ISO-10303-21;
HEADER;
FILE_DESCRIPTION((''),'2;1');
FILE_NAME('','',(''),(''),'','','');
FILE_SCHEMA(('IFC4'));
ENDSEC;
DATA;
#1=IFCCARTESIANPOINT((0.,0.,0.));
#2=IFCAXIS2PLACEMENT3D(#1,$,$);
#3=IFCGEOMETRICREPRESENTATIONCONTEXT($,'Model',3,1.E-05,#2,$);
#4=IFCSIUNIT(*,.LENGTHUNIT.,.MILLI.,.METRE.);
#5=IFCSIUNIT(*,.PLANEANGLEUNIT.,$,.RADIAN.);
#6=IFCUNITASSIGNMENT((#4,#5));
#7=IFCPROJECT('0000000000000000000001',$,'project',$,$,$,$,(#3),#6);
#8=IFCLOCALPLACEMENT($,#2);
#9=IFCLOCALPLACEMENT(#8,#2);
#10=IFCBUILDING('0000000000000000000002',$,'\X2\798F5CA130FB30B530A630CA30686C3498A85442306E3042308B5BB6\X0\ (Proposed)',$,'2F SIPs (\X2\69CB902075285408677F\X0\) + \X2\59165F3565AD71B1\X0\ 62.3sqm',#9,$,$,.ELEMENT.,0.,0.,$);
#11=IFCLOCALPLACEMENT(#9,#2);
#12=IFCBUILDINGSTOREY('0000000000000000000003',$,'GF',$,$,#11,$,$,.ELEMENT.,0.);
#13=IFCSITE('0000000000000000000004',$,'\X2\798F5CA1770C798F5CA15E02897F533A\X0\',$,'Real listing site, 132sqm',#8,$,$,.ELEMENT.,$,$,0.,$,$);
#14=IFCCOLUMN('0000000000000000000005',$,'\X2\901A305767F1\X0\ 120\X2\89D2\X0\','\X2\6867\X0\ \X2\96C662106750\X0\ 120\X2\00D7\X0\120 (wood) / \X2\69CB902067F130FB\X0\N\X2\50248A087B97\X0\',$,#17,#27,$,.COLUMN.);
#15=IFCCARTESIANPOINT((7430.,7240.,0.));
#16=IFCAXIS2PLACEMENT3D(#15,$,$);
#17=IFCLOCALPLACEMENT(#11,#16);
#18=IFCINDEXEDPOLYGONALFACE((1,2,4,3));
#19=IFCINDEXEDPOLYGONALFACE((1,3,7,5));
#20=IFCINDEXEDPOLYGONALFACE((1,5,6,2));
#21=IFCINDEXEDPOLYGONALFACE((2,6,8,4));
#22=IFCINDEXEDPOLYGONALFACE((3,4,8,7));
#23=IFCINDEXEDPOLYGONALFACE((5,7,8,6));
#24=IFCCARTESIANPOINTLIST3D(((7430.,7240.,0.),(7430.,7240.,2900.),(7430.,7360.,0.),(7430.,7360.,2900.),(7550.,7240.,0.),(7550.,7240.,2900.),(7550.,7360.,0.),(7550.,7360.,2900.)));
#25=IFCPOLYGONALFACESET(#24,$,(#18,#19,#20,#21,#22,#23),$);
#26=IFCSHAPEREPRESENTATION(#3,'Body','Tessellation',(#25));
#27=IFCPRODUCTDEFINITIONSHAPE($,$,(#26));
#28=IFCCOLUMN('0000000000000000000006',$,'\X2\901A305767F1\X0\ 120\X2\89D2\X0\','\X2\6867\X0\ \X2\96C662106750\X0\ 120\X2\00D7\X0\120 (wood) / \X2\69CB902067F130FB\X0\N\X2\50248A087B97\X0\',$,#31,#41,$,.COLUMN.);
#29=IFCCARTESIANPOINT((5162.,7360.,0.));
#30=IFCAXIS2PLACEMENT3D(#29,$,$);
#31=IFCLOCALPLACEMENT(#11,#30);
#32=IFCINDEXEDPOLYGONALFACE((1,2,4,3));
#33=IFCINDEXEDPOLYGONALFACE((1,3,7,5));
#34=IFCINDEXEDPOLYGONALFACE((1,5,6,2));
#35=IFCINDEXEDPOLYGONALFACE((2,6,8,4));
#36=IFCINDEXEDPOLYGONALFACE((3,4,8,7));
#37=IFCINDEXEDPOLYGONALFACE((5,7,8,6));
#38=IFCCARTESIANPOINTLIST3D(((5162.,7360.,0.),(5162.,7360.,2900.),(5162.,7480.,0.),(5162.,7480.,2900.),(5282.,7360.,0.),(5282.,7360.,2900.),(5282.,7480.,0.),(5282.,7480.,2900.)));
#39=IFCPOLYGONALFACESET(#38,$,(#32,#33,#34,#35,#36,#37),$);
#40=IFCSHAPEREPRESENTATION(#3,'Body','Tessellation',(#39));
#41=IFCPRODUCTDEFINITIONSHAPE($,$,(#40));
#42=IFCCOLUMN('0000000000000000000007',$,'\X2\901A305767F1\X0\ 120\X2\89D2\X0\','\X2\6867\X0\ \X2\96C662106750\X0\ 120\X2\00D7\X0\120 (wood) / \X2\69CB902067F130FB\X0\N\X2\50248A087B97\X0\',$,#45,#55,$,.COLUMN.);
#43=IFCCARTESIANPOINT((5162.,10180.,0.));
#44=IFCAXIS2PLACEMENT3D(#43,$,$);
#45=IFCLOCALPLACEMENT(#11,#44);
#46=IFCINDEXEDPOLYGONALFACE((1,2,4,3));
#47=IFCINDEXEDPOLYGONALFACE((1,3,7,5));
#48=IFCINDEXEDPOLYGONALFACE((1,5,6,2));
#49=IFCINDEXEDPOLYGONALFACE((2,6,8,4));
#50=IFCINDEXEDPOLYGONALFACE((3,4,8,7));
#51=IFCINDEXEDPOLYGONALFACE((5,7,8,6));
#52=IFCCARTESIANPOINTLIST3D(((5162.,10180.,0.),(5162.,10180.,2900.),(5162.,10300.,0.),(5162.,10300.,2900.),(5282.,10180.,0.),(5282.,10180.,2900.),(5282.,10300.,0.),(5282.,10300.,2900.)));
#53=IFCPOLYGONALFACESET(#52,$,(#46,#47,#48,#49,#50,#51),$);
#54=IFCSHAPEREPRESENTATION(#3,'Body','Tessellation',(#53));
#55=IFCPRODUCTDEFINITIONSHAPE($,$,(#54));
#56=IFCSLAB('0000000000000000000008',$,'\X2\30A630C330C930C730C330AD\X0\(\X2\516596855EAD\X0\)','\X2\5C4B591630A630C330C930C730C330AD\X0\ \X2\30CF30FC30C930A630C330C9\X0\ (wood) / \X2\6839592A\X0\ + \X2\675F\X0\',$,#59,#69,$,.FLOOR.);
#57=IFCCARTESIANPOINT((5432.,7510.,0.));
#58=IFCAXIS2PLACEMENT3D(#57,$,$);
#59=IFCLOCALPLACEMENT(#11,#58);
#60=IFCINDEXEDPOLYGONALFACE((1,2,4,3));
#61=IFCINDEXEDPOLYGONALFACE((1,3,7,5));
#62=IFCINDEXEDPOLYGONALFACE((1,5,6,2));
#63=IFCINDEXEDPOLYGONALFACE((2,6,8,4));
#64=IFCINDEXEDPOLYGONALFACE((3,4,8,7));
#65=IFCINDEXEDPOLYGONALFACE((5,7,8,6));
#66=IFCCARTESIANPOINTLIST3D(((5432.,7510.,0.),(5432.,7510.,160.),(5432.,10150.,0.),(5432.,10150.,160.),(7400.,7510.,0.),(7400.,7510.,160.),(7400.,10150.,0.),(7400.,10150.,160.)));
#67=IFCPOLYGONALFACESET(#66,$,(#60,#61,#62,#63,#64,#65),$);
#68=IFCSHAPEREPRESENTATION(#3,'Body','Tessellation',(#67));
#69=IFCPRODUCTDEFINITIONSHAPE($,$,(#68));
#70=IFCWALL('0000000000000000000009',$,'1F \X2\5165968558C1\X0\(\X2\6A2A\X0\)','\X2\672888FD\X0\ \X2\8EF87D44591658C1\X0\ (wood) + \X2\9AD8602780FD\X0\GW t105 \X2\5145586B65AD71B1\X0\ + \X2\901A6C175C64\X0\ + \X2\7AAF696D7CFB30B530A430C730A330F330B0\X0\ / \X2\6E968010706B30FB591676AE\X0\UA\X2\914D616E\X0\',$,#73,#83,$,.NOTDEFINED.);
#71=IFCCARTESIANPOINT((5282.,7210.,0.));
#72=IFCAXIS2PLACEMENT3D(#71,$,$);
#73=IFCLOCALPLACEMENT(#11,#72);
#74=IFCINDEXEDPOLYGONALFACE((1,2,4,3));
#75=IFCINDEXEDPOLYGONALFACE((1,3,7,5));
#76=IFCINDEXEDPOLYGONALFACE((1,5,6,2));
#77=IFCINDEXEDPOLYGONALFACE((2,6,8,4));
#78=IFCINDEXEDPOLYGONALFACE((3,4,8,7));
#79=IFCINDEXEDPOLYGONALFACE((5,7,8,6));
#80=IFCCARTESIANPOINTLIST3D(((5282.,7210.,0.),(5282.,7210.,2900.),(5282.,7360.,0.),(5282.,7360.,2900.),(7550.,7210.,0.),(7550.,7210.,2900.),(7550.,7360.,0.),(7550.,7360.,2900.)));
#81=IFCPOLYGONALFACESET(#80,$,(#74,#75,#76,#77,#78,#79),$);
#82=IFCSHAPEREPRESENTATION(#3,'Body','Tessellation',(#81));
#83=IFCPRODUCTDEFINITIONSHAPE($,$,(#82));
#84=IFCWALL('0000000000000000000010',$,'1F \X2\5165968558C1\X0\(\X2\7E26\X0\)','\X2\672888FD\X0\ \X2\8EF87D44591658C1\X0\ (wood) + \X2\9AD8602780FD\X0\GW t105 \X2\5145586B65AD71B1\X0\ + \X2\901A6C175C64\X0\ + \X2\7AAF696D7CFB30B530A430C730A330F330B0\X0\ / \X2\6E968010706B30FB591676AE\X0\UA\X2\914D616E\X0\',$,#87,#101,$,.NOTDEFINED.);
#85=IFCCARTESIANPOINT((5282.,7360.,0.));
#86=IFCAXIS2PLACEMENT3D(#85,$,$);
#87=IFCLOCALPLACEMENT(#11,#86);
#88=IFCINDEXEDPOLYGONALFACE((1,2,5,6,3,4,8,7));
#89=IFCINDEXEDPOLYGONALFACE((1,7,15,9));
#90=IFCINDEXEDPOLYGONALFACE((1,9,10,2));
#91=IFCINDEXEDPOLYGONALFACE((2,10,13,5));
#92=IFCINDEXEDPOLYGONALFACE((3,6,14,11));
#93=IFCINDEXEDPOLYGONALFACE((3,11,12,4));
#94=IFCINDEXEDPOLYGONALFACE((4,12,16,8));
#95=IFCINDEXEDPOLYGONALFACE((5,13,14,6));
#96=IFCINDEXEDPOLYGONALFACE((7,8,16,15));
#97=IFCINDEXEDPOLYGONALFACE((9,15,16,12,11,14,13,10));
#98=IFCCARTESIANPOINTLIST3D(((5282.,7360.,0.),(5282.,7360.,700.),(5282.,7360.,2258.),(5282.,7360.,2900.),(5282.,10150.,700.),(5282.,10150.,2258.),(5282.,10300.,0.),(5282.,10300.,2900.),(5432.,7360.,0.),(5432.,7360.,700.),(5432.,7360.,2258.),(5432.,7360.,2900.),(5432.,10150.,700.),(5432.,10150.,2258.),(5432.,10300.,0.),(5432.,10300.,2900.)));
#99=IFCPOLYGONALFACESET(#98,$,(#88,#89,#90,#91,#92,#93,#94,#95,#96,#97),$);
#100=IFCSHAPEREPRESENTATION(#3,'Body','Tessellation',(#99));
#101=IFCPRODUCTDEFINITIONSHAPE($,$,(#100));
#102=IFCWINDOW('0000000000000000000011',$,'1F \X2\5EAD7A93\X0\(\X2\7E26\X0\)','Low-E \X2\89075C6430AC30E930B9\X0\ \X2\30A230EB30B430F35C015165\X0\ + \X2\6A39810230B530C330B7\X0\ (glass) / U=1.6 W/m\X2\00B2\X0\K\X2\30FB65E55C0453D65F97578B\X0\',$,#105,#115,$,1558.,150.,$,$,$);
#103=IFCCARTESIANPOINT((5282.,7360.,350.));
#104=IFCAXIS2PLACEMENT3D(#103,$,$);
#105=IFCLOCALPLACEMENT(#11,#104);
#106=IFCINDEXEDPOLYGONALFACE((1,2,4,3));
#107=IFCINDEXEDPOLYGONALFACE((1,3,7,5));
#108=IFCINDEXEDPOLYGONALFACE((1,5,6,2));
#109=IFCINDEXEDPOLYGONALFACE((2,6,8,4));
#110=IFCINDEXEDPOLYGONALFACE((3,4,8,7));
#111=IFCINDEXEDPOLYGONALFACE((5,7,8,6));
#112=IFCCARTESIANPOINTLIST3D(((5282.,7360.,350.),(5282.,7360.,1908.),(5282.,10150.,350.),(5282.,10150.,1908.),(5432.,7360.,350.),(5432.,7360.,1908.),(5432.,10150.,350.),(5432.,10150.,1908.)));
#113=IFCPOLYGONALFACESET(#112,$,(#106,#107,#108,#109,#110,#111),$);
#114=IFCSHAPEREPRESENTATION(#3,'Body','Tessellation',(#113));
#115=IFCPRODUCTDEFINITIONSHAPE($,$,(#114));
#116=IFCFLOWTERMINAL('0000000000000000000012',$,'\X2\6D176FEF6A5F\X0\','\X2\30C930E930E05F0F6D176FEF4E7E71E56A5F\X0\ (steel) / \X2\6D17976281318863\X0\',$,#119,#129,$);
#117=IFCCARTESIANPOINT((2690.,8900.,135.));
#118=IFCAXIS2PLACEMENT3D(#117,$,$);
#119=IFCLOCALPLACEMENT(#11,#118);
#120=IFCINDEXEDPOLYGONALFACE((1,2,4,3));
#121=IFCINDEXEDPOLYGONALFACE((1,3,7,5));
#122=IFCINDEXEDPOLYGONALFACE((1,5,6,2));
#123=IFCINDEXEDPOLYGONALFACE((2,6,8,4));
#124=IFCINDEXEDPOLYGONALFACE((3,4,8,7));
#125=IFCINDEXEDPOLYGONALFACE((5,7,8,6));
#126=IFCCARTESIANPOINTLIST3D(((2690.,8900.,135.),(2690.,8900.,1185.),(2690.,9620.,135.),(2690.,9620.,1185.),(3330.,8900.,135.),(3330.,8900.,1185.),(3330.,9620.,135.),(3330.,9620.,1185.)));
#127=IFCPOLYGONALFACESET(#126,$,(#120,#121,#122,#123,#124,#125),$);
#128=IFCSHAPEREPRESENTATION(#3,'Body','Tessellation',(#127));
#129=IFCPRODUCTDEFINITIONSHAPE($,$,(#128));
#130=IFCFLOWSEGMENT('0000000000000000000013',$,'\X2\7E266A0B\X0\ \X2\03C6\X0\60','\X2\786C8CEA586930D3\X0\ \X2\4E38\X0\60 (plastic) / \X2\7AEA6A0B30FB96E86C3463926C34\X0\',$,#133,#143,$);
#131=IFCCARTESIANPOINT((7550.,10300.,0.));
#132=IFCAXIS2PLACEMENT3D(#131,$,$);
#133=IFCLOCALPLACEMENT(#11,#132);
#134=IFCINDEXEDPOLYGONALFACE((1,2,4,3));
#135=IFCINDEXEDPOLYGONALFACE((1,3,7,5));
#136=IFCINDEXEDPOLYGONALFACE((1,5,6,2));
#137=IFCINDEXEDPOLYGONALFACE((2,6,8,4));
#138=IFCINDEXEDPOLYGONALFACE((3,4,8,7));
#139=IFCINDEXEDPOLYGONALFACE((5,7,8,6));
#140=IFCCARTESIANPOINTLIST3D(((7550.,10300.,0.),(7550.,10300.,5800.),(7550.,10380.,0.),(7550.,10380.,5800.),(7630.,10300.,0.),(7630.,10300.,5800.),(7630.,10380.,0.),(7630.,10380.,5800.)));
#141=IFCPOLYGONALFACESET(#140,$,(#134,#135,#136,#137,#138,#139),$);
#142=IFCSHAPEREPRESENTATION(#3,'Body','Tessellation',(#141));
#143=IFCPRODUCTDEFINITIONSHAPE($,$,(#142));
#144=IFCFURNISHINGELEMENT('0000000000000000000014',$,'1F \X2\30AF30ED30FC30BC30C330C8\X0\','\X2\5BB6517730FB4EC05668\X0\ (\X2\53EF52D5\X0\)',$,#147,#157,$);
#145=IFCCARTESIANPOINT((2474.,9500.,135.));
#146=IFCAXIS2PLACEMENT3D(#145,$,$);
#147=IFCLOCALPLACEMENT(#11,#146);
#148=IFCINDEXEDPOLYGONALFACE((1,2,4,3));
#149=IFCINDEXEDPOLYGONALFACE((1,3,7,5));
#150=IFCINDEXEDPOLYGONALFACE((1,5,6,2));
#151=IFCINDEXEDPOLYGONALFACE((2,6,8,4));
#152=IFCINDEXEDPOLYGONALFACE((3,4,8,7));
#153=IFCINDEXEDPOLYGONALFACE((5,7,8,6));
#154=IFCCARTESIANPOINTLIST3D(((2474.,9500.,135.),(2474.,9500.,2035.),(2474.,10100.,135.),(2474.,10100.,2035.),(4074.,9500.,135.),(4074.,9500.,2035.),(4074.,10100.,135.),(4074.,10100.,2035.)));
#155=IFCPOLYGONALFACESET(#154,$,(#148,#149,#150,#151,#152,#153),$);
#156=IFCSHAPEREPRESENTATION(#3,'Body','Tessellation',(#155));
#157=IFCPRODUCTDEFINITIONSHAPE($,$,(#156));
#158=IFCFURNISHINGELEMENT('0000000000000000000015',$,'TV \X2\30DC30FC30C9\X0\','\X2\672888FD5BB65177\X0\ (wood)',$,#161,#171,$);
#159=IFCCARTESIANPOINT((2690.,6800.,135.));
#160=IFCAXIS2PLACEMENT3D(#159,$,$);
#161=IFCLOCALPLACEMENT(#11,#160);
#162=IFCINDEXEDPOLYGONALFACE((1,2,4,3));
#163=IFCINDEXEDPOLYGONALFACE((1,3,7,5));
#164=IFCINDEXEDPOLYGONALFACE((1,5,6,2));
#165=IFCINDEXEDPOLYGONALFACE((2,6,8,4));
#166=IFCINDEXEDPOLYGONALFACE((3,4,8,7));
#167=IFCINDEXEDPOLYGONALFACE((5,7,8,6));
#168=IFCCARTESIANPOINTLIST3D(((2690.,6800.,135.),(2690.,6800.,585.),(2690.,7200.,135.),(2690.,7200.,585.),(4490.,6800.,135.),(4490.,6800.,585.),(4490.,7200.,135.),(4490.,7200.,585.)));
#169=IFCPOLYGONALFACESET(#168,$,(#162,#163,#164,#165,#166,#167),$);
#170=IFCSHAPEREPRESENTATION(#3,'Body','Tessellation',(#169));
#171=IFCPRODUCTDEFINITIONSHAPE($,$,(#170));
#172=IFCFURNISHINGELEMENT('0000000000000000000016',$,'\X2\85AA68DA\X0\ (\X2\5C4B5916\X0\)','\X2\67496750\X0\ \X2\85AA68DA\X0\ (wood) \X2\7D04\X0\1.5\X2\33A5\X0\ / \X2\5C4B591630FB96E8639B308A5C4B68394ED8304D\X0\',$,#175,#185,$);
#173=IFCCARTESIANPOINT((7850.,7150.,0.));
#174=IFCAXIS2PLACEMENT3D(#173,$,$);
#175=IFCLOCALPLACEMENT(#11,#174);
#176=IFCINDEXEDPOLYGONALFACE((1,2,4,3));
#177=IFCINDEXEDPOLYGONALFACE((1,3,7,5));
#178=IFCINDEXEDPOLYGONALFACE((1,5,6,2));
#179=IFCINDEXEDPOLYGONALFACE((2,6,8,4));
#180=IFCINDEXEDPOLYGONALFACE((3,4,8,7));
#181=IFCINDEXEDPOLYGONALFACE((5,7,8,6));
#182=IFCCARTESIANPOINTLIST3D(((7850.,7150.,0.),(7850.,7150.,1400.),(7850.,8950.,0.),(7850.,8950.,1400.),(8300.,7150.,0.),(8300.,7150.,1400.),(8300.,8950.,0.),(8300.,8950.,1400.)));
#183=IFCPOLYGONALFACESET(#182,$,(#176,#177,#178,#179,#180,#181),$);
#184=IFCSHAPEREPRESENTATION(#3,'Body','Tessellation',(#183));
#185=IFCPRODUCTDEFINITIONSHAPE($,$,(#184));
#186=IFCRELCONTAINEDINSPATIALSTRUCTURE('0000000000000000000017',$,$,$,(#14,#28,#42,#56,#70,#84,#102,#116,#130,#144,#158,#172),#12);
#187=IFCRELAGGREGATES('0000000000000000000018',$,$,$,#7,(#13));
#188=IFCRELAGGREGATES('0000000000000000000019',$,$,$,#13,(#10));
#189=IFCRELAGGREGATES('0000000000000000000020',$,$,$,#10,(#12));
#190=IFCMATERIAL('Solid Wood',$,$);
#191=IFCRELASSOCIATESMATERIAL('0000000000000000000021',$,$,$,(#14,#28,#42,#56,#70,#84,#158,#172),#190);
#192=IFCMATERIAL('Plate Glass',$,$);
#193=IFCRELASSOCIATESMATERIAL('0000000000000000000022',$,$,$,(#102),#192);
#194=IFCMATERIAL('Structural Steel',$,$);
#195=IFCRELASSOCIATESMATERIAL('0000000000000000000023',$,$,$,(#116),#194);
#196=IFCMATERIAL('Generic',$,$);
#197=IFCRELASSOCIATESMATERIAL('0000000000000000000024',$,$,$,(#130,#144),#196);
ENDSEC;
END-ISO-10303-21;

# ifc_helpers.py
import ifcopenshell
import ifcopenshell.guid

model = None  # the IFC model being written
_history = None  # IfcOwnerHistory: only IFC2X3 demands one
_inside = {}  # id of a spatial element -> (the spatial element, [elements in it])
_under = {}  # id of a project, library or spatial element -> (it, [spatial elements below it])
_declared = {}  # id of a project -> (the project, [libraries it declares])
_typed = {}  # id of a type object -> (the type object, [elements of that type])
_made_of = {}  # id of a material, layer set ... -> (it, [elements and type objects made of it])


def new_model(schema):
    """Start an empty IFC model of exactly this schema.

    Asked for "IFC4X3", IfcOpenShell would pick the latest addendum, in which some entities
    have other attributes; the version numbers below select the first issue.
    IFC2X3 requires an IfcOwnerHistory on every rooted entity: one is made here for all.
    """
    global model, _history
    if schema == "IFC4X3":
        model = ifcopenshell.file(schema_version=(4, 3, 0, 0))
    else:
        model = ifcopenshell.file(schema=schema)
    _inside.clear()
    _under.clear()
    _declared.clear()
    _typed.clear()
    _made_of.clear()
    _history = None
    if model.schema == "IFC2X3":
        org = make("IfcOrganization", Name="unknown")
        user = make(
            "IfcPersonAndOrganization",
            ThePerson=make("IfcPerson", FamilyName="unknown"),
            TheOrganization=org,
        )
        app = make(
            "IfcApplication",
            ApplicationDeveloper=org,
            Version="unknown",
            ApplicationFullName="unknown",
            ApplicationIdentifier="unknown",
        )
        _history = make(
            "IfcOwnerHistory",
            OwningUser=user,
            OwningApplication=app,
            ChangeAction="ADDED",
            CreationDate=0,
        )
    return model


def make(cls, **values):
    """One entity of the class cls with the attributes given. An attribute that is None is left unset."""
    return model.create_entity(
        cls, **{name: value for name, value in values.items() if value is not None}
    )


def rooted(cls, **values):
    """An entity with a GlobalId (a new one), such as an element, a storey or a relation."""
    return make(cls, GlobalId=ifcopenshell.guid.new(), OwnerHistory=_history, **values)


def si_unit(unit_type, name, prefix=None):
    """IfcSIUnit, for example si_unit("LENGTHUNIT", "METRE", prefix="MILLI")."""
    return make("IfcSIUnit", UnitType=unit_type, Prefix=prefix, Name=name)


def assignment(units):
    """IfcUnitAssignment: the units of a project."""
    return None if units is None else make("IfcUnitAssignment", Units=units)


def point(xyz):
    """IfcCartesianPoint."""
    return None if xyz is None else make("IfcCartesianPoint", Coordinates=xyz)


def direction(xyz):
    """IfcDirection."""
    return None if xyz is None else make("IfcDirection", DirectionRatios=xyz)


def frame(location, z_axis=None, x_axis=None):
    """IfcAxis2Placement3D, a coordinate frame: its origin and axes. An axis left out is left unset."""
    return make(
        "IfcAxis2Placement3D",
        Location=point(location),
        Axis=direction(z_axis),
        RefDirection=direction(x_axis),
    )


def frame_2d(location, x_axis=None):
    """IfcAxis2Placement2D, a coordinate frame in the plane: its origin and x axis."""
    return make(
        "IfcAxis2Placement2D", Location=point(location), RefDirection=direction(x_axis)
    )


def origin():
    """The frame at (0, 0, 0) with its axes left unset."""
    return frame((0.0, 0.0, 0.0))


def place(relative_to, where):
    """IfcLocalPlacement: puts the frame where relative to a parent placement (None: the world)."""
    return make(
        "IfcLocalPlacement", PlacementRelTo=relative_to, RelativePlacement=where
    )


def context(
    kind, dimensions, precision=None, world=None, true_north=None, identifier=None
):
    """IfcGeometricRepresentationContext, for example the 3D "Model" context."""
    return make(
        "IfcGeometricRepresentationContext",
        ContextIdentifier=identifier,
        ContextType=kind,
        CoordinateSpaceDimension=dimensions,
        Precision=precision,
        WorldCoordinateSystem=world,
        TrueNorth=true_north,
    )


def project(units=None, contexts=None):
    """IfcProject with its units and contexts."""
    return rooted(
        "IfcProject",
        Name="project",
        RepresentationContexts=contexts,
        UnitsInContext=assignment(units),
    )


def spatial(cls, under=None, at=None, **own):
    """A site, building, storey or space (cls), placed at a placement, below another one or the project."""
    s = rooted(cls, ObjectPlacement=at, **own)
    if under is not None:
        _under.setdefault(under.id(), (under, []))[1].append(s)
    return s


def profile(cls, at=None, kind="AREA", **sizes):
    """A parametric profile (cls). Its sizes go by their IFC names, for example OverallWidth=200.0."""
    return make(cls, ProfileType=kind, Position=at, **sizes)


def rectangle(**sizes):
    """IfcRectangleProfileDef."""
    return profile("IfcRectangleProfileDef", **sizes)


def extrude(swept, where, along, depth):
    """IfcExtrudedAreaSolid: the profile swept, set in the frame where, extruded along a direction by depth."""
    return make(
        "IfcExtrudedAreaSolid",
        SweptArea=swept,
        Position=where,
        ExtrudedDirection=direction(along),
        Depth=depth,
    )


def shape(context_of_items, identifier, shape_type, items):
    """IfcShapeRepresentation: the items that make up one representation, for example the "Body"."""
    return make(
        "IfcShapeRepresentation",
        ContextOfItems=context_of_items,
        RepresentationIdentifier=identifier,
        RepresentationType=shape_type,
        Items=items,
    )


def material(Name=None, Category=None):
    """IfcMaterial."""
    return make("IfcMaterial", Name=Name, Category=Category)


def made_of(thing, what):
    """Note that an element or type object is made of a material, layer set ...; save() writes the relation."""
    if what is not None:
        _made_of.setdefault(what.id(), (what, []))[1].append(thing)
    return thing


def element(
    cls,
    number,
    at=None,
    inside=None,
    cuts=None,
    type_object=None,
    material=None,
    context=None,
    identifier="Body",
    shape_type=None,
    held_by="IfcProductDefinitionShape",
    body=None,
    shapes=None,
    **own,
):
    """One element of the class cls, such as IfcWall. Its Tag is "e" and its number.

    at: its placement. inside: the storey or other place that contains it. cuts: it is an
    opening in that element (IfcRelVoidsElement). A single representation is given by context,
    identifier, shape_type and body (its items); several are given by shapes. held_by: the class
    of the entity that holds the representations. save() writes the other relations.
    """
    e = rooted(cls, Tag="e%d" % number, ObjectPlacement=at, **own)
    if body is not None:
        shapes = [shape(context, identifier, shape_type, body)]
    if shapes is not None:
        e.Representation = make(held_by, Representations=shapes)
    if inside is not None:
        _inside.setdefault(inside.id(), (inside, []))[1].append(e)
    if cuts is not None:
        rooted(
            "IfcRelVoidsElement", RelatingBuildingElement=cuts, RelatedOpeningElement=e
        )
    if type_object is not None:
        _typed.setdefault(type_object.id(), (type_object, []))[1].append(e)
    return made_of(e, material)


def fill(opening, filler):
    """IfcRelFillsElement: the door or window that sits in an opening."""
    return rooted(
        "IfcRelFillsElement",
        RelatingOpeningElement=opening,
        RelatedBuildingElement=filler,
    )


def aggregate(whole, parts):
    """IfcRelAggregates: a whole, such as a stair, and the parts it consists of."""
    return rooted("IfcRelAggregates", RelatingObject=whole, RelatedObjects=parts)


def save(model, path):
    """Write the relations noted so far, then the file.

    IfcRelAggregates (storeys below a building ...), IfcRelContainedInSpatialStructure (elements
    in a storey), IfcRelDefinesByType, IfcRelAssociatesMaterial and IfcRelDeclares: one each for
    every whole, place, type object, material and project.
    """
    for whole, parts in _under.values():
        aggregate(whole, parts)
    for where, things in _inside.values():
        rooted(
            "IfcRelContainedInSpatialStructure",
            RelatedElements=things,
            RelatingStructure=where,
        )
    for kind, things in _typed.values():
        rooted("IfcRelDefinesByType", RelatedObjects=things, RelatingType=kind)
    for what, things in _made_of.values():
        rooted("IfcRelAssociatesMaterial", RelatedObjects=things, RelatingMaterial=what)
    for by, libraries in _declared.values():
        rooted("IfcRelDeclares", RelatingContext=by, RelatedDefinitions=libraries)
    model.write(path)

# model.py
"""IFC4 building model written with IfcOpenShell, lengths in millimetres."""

from ifc_helpers import new_model, si_unit, frame, frame_2d, origin, place, context, project, spatial, rectangle, extrude, material, element, fill, save


model = new_model("IFC4")

# Units and contexts
model_context = context("Model", 3, precision=1e-05, world=origin())
ifc_project = project(units=[si_unit("LENGTHUNIT", "METRE", prefix="MILLI"), si_unit("PLANEANGLEUNIT", "RADIAN")], contexts=[model_context])

# Site, building, storey
site_placement = place(None, origin())
site = spatial("IfcSite", under=ifc_project, at=site_placement, Name="福岡県福岡市西区", ObjectType="Real listing site, 132sqm", CompositionType="ELEMENT", RefElevation=0.0)
building_placement = place(site_placement, origin())
building = spatial("IfcBuilding", under=site, at=building_placement, Name="福岡・サウナと水風呂のある家 (Proposed)", ObjectType="2F SIPs (構造用合板) + 外張断熱 62.3sqm", CompositionType="ELEMENT", ElevationOfRefHeight=0.0, ElevationOfTerrain=0.0)
storey_placement = place(building_placement, origin())
storey = spatial("IfcBuildingStorey", under=building, at=storey_placement, Name="GF", CompositionType="ELEMENT", Elevation=0.0)

# Columns
ifc_material_1 = material(Name="Solid Wood")
column_1_placement = place(storey_placement, frame((7430.0, 7240.0, 0.0)))
element("IfcColumn", 1, at=column_1_placement, inside=storey, material=ifc_material_1, Name="通し柱 120角", Description="桧 集成材 120×120 (wood) / 構造柱・N値計算", PredefinedType="COLUMN", context=model_context, shape_type="SweptSolid", body=[
    extrude(rectangle(XDim=120.0, YDim=120.0, at=frame_2d((60.0, 60.0))), frame((7430.0, 7240.0, 0.0)), (0.0, 0.0, 1.0), 2900.0),
])
column_2_placement = place(storey_placement, frame((5162.0, 7360.0, 0.0)))
element("IfcColumn", 2, at=column_2_placement, inside=storey, material=ifc_material_1, Name="通し柱 120角", Description="桧 集成材 120×120 (wood) / 構造柱・N値計算", PredefinedType="COLUMN", context=model_context, shape_type="SweptSolid", body=[
    extrude(rectangle(XDim=120.0, YDim=120.0, at=frame_2d((60.0, 60.0))), frame((5162.0, 7360.0, 0.0)), (0.0, 0.0, 1.0), 2900.0),
])
column_3_placement = place(storey_placement, frame((5162.0, 10180.0, 0.0)))
element("IfcColumn", 3, at=column_3_placement, inside=storey, material=ifc_material_1, Name="通し柱 120角", Description="桧 集成材 120×120 (wood) / 構造柱・N値計算", PredefinedType="COLUMN", context=model_context, shape_type="SweptSolid", body=[
    extrude(rectangle(XDim=120.0, YDim=120.0, at=frame_2d((60.0, 60.0))), frame((5162.0, 10180.0, 0.0)), (0.0, 0.0, 1.0), 2900.0),
])

# Slab
slab_placement = place(storey_placement, frame((5432.0, 7510.0, 0.0)))
element("IfcSlab", 4, at=slab_placement, inside=storey, material=ifc_material_1, Name="ウッドデッキ(入隅庭)", Description="屋外ウッドデッキ ハードウッド (wood) / 根太 + 束", PredefinedType="FLOOR", context=model_context, shape_type="SweptSolid", body=[
    extrude(rectangle(XDim=1968.0, YDim=2640.0, at=frame_2d((984.0, 1320.0))), frame((5432.0, 7510.0, 0.0)), (0.0, 0.0, 1.0), 160.0),
])

# Wall
wall_1_placement = place(storey_placement, frame((5282.0, 7210.0, 0.0)))
element("IfcWall", 5, at=wall_1_placement, inside=storey, material=ifc_material_1, Name="1F 入隅壁(横)", Description="木製 軸組外壁 (wood) + 高性能GW t105 充填断熱 + 通気層 + 窯業系サイディング / 準耐火・外皮UA配慮", PredefinedType="NOTDEFINED", context=model_context, shape_type="SweptSolid", body=[
    extrude(rectangle(XDim=2268.0, YDim=150.0, at=frame_2d((1134.0, 75.0))), frame((5282.0, 7210.0, 0.0)), (0.0, 0.0, 1.0), 2900.0),
])

# Wall, opening, window
wall_2_placement = place(storey_placement, frame((5282.0, 7360.0, 0.0)))
wall_2 = element("IfcWall", 6, at=wall_2_placement, inside=storey, material=ifc_material_1, Name="1F 入隅壁(縦)", Description="木製 軸組外壁 (wood) + 高性能GW t105 充填断熱 + 通気層 + 窯業系サイディング / 準耐火・外皮UA配慮", PredefinedType="NOTDEFINED", context=model_context, shape_type="SweptSolid", body=[
    extrude(rectangle(XDim=150.0, YDim=2940.0, at=frame_2d((75.0, 1470.0))), frame((5282.0, 7360.0, 0.0)), (0.0, 0.0, 1.0), 2900.0),
])
opening_placement = place(storey_placement, frame((5282.0, 7360.0, 350.0)))
opening = element("IfcOpeningElement", 7, at=opening_placement, cuts=wall_2, PredefinedType="NOTDEFINED", context=model_context, shape_type="SweptSolid", body=[
    extrude(rectangle(XDim=150.0, YDim=2790.0, at=frame_2d((75.0, 1395.0))), frame((5282.0, 7360.0, 350.0)), (0.0, 0.0, 1.0), 1558.0),
])
ifc_material_2 = material(Name="Plate Glass")
window_placement = place(storey_placement, frame((5282.0, 7360.0, 350.0)))
window = element("IfcWindow", 8, at=window_placement, inside=storey, material=ifc_material_2, Name="1F 庭窓(縦)", Description="Low-E 複層ガラス アルゴン封入 + 樹脂サッシ (glass) / U=1.6 W/m²K・日射取得型", OverallHeight=1558.0, OverallWidth=150.0, context=model_context, shape_type="SweptSolid", body=[
    extrude(rectangle(XDim=150.0, YDim=2790.0, at=frame_2d((75.0, 1395.0))), frame((5282.0, 7360.0, 350.0)), (0.0, 0.0, 1.0), 1558.0),
])
fill(opening, window)

# Flow terminal
ifc_material_3 = material(Name="Structural Steel")
flow_terminal_placement = place(storey_placement, frame((2690.0, 8900.0, 135.0)))
element("IfcFlowTerminal", 9, at=flow_terminal_placement, inside=storey, material=ifc_material_3, Name="洗濯機", Description="ドラム式洗濯乾燥機 (steel) / 洗面脱衣", context=model_context, shape_type="SweptSolid", body=[
    extrude(rectangle(XDim=640.0, YDim=720.0, at=frame_2d((320.0, 360.0))), frame((2690.0, 8900.0, 135.0)), (0.0, 0.0, 1.0), 1050.0),
])

# Flow segment
ifc_material_4 = material(Name="Generic")
flow_segment_placement = place(storey_placement, frame((7550.0, 10300.0, 0.0)))
element("IfcFlowSegment", 10, at=flow_segment_placement, inside=storey, material=ifc_material_4, Name="縦樋 φ60", Description="硬質塩ビ 丸60 (plastic) / 竪樋・雨水排水", context=model_context, shape_type="SweptSolid", body=[
    extrude(rectangle(XDim=80.0, YDim=80.0, at=frame_2d((40.0, 40.0))), frame((7550.0, 10300.0, 0.0)), (0.0, 0.0, 1.0), 5800.0),
])

# Furnishing elements
furnishing_1_placement = place(storey_placement, frame((2474.0, 9500.0, 135.0)))
element("IfcFurnishingElement", 11, at=furnishing_1_placement, inside=storey, material=ifc_material_4, Name="1F クローゼット", Description="家具・什器 (可動)", context=model_context, shape_type="SweptSolid", body=[
    extrude(rectangle(XDim=1600.0, YDim=600.0, at=frame_2d((800.0, 300.0))), frame((2474.0, 9500.0, 135.0)), (0.0, 0.0, 1.0), 1900.0),
])
furnishing_2_placement = place(storey_placement, frame((2690.0, 6800.0, 135.0)))
element("IfcFurnishingElement", 12, at=furnishing_2_placement, inside=storey, material=ifc_material_1, Name="TV ボード", Description="木製家具 (wood)", context=model_context, shape_type="SweptSolid", body=[
    extrude(rectangle(XDim=1800.0, YDim=400.0, at=frame_2d((900.0, 200.0))), frame((2690.0, 6800.0, 135.0)), (0.0, 0.0, 1.0), 450.0),
])
furnishing_3_placement = place(storey_placement, frame((7850.0, 7150.0, 0.0)))
element("IfcFurnishingElement", 13, at=furnishing_3_placement, inside=storey, material=ifc_material_1, Name="薪棚 (屋外)", Description="杉材 薪棚 (wood) 約1.5㎥ / 屋外・雨掛り屋根付き", context=model_context, shape_type="SweptSolid", body=[
    extrude(rectangle(XDim=450.0, YDim=1800.0, at=frame_2d((225.0, 900.0))), frame((7850.0, 7150.0, 0.0)), (0.0, 0.0, 1.0), 1400.0),
])

save(model, "model.ifc")
